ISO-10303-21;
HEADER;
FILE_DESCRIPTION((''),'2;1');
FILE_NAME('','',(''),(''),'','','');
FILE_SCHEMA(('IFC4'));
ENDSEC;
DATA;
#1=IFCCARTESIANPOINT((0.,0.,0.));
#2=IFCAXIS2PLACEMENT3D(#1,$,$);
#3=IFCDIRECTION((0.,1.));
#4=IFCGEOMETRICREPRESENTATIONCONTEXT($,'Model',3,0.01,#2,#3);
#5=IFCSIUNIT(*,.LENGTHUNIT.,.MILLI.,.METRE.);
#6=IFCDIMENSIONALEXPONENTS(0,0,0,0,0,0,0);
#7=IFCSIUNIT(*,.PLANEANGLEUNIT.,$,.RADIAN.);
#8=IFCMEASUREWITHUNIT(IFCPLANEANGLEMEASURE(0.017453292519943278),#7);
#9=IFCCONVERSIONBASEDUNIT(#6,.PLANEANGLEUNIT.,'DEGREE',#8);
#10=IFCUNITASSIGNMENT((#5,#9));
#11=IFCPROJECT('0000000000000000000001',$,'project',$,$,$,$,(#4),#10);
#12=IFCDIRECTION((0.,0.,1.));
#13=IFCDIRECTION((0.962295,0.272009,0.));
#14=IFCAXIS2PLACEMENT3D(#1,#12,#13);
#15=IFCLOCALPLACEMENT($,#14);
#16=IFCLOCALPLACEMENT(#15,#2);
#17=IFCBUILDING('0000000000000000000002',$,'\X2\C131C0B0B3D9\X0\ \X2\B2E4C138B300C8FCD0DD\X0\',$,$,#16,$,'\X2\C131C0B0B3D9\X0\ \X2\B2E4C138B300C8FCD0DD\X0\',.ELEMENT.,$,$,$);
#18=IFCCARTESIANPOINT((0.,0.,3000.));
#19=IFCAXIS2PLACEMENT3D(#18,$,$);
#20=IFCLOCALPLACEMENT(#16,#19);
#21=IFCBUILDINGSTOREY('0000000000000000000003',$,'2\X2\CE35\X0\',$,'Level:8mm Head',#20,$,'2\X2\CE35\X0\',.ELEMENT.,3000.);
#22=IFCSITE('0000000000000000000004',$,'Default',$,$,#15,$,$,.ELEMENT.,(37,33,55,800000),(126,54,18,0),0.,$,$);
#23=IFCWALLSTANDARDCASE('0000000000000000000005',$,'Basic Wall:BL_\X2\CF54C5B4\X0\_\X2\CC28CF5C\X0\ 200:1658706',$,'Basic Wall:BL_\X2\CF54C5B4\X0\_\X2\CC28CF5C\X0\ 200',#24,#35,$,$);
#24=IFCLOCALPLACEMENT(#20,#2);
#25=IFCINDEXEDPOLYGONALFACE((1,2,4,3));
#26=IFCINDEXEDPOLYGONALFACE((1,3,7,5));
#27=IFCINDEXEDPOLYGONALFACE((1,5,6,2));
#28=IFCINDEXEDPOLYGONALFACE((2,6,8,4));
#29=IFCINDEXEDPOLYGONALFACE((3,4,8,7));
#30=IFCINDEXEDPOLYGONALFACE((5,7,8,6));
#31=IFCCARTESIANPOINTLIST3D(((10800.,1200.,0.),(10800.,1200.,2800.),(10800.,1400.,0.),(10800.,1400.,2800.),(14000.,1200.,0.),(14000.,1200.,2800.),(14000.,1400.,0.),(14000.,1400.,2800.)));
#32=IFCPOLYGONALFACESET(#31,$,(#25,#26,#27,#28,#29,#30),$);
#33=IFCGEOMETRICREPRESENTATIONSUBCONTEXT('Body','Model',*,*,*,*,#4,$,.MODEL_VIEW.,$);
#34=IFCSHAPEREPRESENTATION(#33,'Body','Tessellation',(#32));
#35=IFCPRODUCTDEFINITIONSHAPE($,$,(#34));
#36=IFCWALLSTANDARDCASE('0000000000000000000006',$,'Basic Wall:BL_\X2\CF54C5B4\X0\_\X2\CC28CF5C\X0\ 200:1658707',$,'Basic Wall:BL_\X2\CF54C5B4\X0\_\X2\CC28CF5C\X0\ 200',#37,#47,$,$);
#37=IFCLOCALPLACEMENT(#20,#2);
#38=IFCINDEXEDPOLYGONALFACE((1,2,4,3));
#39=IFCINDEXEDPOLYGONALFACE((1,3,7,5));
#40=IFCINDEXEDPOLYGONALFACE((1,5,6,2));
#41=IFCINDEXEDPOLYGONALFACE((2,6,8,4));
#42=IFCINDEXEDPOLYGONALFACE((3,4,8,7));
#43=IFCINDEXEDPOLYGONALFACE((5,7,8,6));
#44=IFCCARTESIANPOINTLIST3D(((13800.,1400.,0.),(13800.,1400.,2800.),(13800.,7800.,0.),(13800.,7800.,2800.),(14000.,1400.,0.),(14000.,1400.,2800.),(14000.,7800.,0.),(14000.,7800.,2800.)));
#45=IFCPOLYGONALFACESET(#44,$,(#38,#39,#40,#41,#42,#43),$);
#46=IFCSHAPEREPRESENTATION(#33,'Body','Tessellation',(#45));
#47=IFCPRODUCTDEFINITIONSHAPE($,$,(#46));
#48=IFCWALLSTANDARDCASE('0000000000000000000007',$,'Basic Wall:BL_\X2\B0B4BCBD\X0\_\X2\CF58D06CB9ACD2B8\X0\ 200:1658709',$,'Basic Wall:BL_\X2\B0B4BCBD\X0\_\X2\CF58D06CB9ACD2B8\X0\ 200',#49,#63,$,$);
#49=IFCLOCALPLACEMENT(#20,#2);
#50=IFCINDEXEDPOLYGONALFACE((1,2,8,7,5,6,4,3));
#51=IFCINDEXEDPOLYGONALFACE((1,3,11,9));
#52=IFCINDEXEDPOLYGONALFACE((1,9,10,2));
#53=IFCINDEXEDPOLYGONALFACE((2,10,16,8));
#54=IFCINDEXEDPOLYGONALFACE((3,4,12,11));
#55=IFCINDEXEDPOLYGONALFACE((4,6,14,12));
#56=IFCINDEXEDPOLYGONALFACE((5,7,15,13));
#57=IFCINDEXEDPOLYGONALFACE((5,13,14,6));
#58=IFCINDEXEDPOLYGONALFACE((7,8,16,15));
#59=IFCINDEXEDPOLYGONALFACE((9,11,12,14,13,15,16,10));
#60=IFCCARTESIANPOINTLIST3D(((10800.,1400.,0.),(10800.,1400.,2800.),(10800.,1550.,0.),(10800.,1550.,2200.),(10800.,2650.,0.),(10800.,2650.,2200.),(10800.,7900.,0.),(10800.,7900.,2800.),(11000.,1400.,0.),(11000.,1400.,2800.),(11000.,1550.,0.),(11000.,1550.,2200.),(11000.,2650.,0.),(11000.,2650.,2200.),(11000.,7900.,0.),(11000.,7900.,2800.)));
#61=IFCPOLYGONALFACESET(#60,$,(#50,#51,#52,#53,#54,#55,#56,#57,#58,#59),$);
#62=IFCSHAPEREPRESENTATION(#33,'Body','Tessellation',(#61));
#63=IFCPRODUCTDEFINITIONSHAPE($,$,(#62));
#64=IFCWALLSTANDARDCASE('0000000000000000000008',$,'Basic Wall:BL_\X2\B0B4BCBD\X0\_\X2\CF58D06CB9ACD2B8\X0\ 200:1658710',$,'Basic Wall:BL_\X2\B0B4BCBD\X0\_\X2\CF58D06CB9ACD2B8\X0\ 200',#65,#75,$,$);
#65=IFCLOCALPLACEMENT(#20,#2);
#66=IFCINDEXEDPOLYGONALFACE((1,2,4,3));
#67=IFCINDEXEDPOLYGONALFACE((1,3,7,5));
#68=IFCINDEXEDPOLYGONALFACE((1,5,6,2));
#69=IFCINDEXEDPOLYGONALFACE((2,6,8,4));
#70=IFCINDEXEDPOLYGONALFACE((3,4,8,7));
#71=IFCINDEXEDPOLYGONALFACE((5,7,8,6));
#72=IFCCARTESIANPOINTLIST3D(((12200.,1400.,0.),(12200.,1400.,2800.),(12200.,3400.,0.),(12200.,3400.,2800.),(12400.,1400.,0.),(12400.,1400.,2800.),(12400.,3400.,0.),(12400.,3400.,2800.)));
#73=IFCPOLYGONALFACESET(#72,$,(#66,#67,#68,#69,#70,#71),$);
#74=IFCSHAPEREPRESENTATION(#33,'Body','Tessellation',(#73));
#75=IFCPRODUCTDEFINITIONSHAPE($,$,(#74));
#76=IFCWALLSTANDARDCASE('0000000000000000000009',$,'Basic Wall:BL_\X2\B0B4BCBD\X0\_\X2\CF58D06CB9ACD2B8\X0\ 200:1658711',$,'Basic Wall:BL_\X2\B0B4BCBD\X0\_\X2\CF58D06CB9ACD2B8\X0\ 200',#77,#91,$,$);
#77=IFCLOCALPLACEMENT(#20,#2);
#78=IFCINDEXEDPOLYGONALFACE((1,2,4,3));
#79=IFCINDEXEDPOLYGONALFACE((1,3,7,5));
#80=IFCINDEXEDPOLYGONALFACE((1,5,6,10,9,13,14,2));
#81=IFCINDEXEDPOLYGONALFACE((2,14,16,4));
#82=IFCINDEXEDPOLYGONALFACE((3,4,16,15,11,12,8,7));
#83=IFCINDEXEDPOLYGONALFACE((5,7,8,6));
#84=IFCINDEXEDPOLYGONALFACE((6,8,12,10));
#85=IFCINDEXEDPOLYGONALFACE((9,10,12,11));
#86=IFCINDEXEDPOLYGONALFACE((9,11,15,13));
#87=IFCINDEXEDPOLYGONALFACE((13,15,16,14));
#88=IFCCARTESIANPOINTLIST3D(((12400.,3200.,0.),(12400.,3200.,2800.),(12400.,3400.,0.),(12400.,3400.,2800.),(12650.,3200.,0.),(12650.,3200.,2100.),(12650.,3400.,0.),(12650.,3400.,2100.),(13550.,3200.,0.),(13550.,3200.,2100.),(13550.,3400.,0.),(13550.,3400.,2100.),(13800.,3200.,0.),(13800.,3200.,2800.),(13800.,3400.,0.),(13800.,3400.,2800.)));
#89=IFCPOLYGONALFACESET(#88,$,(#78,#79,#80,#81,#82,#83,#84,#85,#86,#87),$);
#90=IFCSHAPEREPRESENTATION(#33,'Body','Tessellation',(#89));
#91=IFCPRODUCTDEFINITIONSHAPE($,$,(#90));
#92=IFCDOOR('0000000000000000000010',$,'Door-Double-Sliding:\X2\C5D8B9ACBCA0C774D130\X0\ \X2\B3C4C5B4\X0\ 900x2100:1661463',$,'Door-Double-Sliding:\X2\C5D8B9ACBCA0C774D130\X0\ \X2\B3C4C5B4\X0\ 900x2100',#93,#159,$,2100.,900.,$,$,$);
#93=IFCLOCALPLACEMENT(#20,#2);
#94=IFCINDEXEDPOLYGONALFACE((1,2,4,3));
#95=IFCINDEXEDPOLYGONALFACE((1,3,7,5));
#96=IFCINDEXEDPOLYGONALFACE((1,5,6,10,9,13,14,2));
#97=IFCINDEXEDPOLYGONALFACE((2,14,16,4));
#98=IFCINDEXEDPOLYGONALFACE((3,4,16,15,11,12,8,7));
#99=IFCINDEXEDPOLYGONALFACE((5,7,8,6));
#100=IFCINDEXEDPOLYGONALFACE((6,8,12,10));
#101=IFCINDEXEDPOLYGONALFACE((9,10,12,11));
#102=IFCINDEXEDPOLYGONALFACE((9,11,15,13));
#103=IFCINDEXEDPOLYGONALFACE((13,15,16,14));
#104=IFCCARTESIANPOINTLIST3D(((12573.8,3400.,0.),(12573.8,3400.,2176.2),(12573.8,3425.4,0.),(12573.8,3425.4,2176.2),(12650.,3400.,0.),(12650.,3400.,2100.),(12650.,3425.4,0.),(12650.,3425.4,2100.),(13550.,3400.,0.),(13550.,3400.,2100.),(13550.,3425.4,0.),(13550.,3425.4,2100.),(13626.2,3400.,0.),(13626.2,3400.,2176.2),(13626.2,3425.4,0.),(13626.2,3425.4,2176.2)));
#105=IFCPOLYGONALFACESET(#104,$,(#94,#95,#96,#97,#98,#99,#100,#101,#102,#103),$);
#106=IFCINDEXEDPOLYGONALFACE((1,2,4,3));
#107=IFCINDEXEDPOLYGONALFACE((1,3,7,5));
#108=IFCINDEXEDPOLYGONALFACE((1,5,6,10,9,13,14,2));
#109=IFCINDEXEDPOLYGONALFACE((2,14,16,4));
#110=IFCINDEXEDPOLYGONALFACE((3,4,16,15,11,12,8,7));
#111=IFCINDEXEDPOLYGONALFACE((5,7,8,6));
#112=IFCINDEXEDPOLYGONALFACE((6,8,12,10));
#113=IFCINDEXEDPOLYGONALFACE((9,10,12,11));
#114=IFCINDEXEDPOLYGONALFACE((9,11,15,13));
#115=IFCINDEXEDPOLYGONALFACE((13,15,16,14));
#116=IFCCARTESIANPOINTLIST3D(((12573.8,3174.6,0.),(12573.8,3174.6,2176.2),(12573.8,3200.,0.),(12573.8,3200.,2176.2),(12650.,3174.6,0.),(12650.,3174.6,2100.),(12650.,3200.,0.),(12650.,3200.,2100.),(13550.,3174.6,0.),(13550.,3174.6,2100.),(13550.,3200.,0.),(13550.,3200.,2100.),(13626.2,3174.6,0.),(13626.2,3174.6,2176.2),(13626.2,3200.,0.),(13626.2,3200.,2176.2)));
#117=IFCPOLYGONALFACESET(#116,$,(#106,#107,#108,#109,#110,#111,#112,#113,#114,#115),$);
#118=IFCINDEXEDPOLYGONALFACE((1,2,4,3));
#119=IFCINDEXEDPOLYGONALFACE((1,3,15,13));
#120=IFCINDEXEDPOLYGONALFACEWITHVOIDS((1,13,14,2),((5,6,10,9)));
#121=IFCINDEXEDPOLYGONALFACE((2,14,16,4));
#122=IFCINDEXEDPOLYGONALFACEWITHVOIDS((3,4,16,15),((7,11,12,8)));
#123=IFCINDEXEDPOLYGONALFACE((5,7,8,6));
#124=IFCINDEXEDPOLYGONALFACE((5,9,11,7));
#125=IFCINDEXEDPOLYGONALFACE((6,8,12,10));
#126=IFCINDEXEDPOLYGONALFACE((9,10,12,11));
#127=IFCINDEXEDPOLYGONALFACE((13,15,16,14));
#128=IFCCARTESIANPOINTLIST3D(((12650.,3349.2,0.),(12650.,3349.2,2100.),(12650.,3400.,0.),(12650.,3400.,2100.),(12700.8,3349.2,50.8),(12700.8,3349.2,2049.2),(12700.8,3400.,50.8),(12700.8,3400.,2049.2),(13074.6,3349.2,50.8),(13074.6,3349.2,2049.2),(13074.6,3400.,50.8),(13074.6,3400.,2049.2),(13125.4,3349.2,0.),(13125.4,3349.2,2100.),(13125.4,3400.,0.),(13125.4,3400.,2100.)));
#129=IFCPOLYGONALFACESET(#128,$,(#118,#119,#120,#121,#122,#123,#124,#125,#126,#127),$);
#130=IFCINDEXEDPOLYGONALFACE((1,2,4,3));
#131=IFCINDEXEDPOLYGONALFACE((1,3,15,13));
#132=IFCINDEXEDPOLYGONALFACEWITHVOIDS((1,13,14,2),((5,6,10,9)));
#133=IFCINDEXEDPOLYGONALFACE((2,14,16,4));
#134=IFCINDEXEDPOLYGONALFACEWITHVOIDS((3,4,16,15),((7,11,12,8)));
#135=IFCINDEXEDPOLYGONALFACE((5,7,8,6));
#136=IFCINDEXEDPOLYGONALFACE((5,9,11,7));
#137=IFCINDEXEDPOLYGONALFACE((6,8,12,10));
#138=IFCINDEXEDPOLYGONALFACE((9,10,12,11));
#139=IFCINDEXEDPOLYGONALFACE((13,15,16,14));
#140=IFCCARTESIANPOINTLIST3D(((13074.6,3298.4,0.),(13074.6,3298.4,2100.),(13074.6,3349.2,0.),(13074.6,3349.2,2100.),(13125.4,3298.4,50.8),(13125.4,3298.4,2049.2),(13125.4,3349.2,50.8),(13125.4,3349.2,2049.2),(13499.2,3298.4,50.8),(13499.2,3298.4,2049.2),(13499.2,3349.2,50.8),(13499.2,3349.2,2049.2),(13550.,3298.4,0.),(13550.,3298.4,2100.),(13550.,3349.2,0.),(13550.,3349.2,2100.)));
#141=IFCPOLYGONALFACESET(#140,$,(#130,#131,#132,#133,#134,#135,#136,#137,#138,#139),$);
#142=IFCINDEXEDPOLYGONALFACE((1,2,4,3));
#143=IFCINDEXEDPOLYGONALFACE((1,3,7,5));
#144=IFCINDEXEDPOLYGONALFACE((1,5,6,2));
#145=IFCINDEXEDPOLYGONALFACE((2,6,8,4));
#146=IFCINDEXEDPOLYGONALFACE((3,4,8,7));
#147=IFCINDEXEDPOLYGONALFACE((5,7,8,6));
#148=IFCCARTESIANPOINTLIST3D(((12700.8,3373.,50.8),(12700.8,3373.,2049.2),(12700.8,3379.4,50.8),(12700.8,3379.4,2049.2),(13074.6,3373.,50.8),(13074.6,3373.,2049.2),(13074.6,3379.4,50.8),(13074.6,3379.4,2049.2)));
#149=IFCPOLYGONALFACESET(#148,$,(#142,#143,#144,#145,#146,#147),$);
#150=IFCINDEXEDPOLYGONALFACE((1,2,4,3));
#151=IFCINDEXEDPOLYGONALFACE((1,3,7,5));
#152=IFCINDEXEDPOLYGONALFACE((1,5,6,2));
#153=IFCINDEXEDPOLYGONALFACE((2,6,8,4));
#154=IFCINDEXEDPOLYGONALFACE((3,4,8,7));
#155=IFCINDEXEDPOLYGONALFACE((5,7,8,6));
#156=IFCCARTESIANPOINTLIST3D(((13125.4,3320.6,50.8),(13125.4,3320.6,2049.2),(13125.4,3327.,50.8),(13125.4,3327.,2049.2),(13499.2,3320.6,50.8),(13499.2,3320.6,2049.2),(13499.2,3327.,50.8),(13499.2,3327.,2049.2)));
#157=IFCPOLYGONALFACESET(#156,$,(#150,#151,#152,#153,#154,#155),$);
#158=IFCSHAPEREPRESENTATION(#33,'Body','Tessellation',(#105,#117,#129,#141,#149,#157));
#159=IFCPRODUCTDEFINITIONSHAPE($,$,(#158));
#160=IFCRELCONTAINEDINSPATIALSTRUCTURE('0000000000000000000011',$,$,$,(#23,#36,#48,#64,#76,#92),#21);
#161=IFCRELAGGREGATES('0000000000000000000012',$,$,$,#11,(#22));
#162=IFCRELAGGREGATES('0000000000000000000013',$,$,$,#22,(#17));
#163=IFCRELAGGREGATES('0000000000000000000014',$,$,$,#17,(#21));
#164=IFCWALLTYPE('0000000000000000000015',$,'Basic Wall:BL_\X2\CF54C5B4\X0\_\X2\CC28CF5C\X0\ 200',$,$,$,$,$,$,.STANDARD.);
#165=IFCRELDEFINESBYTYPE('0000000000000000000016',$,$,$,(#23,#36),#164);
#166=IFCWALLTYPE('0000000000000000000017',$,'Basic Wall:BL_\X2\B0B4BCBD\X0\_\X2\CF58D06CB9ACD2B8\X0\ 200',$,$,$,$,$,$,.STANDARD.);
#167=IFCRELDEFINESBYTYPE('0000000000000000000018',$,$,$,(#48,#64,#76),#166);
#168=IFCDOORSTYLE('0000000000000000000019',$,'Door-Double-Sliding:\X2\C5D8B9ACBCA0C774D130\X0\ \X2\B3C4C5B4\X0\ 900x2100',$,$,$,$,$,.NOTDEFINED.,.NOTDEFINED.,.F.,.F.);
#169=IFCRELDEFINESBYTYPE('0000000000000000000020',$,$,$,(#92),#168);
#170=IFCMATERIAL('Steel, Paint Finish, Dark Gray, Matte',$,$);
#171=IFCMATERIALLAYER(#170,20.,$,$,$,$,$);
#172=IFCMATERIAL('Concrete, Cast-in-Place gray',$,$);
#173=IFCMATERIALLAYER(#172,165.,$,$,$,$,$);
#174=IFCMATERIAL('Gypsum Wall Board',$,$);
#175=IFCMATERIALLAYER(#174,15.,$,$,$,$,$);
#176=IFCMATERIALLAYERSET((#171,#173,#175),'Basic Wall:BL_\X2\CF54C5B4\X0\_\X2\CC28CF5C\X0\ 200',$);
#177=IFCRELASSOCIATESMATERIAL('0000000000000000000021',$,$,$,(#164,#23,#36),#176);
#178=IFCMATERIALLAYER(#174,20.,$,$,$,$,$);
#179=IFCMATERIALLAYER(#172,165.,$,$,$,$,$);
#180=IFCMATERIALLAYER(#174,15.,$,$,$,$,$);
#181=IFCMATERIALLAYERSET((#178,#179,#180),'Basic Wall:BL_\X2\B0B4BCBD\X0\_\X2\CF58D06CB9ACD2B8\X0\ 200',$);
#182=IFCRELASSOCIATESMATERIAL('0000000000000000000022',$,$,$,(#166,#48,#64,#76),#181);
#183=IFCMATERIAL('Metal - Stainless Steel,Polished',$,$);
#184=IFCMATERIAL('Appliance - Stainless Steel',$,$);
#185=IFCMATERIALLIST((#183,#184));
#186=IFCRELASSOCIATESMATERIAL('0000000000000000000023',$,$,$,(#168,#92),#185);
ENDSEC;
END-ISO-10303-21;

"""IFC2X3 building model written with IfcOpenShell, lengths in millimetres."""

from ifc_helpers import new_model, entity, si_unit, converted_unit, direction, frame, frame_2d, origin, place, context, subcontext, project, spatial, polyline, rectangle, outline, extrude, source, transform, mapped, material, material_list, layer, layer_set, layer_usage, type_object, type_shapes, element, fill, save


model = new_model("IFC2X3")

# Units and contexts
model_context = context("Model", 3, precision=0.01, world=origin(), true_north=direction((0.0, 1.0)))
body_context = subcontext(model_context, "Body", "Model", "MODEL_VIEW")
ifc_project = project(units=[si_unit("LENGTHUNIT", "METRE", prefix="MILLI"), converted_unit("PLANEANGLEUNIT", "DEGREE", entity("IfcPlaneAngleMeasure", 0.017453292519943278), si_unit("PLANEANGLEUNIT", "RADIAN"), dimensions=[0, 0, 0, 0, 0, 0, 0])], contexts=[model_context])

# Site, building, storey
site_placement = place(None, frame((0.0, 0.0, 0.0), z_axis=(0.0, 0.0, 1.0), x_axis=(0.962295, 0.272009, 0.0)))
site = spatial("IfcSite", under=ifc_project, at=site_placement, Name="Default", CompositionType="ELEMENT", RefLatitude=(37, 33, 55, 800000), RefLongitude=(126, 54, 18, 0), RefElevation=0.0)
building_placement = place(site_placement, origin())
building = spatial("IfcBuilding", under=site, at=building_placement, Name="성산동 다세대주택", LongName="성산동 다세대주택", CompositionType="ELEMENT")
storey_placement = place(building_placement, frame((0.0, 0.0, 3000.0)))
storey = spatial("IfcBuildingStorey", under=building, at=storey_placement, Name="2층", ObjectType="Level:8mm Head", LongName="2층", CompositionType="ELEMENT", Elevation=3000.0)

# Walls
ifc_material_1 = material(Name="Steel, Paint Finish, Dark Gray, Matte")
ifc_layer_1 = layer(ifc_material_1, 20.0)
ifc_material_2 = material(Name="Concrete, Cast-in-Place gray")
ifc_layer_2 = layer(ifc_material_2, 165.0)
ifc_material_3 = material(Name="Gypsum Wall Board")
ifc_layer_3 = layer(ifc_material_3, 15.0)
ifc_layer_set_1 = layer_set([ifc_layer_1, ifc_layer_2, ifc_layer_3], Name="Basic Wall:BL_코어_차콜 200")
ifc_layer_usage_1 = layer_usage(ifc_layer_set_1, "AXIS2", "POSITIVE", -100.0)
wall_type_1 = type_object("IfcWallType", Name="Basic Wall:BL_코어_차콜 200", PredefinedType="STANDARD", material=ifc_layer_set_1)
wall_1_placement = place(storey_placement, frame((10800.0, 1300.0, 0.0)))
element("IfcWallStandardCase", 1, at=wall_1_placement, inside=storey, type_object=wall_type_1, material=ifc_layer_usage_1, Name="Basic Wall:BL_코어_차콜 200:1658706", ObjectType="Basic Wall:BL_코어_차콜 200", context=body_context, shape_type="SweptSolid", body=[
    extrude(rectangle(XDim=3200.0, YDim=200.0, at=frame_2d((1600.0, 0.0), x_axis=(-1.0, 0.0))), origin(), (0.0, 0.0, 1.0), 2800.0),
])
ifc_layer_usage_2 = layer_usage(ifc_layer_set_1, "AXIS2", "POSITIVE", -100.0)
wall_2_placement = place(storey_placement, frame((13900.0, 1400.0, 0.0), z_axis=(0.0, 0.0, 1.0), x_axis=(0.0, 1.0, 0.0)))
element("IfcWallStandardCase", 2, at=wall_2_placement, inside=storey, type_object=wall_type_1, material=ifc_layer_usage_2, Name="Basic Wall:BL_코어_차콜 200:1658707", ObjectType="Basic Wall:BL_코어_차콜 200", context=body_context, shape_type="SweptSolid", body=[
    extrude(rectangle(XDim=6400.0, YDim=200.0, at=frame_2d((3200.0, 0.0), x_axis=(-1.0, 0.0))), origin(), (0.0, 0.0, 1.0), 2800.0),
])

# Wall, openings
ifc_layer_4 = layer(ifc_material_3, 20.0)
ifc_layer_5 = layer(ifc_material_2, 165.0)
ifc_layer_6 = layer(ifc_material_3, 15.0)
ifc_layer_set_2 = layer_set([ifc_layer_4, ifc_layer_5, ifc_layer_6], Name="Basic Wall:BL_내벽_콘크리트 200")
ifc_layer_usage_3 = layer_usage(ifc_layer_set_2, "AXIS2", "NEGATIVE", 100.0)
wall_type_2 = type_object("IfcWallType", Name="Basic Wall:BL_내벽_콘크리트 200", PredefinedType="STANDARD", material=ifc_layer_set_2)
wall_3_placement = place(storey_placement, frame((10900.0, 7900.0, 0.0), z_axis=(0.0, 0.0, 1.0), x_axis=(0.0, -1.0, 0.0)))
wall_3 = element("IfcWallStandardCase", 3, at=wall_3_placement, inside=storey, type_object=wall_type_2, material=ifc_layer_usage_3, Name="Basic Wall:BL_내벽_콘크리트 200:1658709", ObjectType="Basic Wall:BL_내벽_콘크리트 200", context=body_context, shape_type="SweptSolid", body=[
    extrude(rectangle(XDim=6500.0, YDim=200.0, at=frame_2d((3250.0, 0.0), x_axis=(1.0, 0.0))), origin(), (0.0, 0.0, 1.0), 2800.0),
])
opening_1_placement = place(wall_3_placement, origin())
element("IfcOpeningElement", 4, at=opening_1_placement, cuts=wall_3, ObjectType="Opening", context=body_context, shape_type="SweptSolid", body=[
    extrude(rectangle(XDim=2200.0, YDim=1100.0, at=frame_2d((0.0, 0.0), x_axis=(0.0, 1.0))), frame((5800.0, -1624.0, 3900.0), z_axis=(0.0, 1.0, 0.0), x_axis=(-1.0, 0.0, 0.0)), (0.0, 0.0, 1.0), 3048.0),
])
opening_2_placement = place(wall_3_placement, frame((5250.0, -100.0, 0.0)))
element("IfcOpeningElement", 5, at=opening_2_placement, cuts=wall_3, ObjectType="Opening", context=body_context, shape_type="SweptSolid", body=[
    extrude(rectangle(XDim=2200.0, YDim=1100.0, at=frame_2d((1100.0, 550.0), x_axis=(1.0, 0.0))), frame((0.0, 0.0, 0.0), z_axis=(0.0, 1.0, 0.0), x_axis=(0.0, 0.0, 1.0)), (0.0, 0.0, 1.0), 200.0),
])

# Wall
ifc_layer_usage_4 = layer_usage(ifc_layer_set_2, "AXIS2", "NEGATIVE", 100.0)
wall_4_placement = place(storey_placement, frame((12300.0, 1400.0, 0.0), z_axis=(0.0, 0.0, 1.0), x_axis=(0.0, 1.0, 0.0)))
element("IfcWallStandardCase", 6, at=wall_4_placement, inside=storey, type_object=wall_type_2, material=ifc_layer_usage_4, Name="Basic Wall:BL_내벽_콘크리트 200:1658710", ObjectType="Basic Wall:BL_내벽_콘크리트 200", context=body_context, shape_type="SweptSolid", body=[
    extrude(rectangle(XDim=2000.0, YDim=200.0, at=frame_2d((1000.0, 0.0), x_axis=(-1.0, 0.0))), origin(), (0.0, 0.0, 1.0), 2800.0),
])

# Wall, opening, door
ifc_layer_usage_5 = layer_usage(ifc_layer_set_2, "AXIS2", "NEGATIVE", 100.0)
wall_5_placement = place(storey_placement, frame((12400.0, 3300.0, 0.0)))
wall_5 = element("IfcWallStandardCase", 7, at=wall_5_placement, inside=storey, type_object=wall_type_2, material=ifc_layer_usage_5, Name="Basic Wall:BL_내벽_콘크리트 200:1658711", ObjectType="Basic Wall:BL_내벽_콘크리트 200", context=body_context, shape_type="SweptSolid", body=[
    extrude(rectangle(XDim=1400.0, YDim=200.0, at=frame_2d((700.0, 0.0), x_axis=(1.0, 0.0))), origin(), (0.0, 0.0, 1.0), 2800.0),
])
opening_3_placement = place(wall_5_placement, frame((250.0, -100.0, 0.0)))
opening_3 = element("IfcOpeningElement", 8, at=opening_3_placement, cuts=wall_5, ObjectType="Opening", context=body_context, shape_type="SweptSolid", body=[
    extrude(rectangle(XDim=2100.0, YDim=900.0, at=frame_2d((1050.0, 450.0), x_axis=(-1.0, 0.0))), frame((0.0, 0.0, 0.0), z_axis=(0.0, 1.0, 0.0), x_axis=(0.0, 0.0, 1.0)), (0.0, 0.0, 1.0), 200.0),
])
ifc_material_4 = material(Name="Metal - Stainless Steel,Polished")
ifc_material_5 = material(Name="Appliance - Stainless Steel")
ifc_material_list = material_list([ifc_material_4, ifc_material_5])
door_style = type_object("IfcDoorStyle", Name="Door-Double-Sliding:엘리베이터 도어 900x2100", ConstructionType="NOTDEFINED", OperationType="NOTDEFINED", ParameterTakesPrecedence=False, Sizeable=False, material=ifc_material_list)
shared_shape_1 = source(origin(), body_context, "Body", "SweptSolid", [
    extrude(outline(polyline([(-526.2, -1069.1), (-450.0, -1069.1), (-450.0, 1030.9), (450.0, 1031.0), (450.0, -1069.0), (526.2, -1069.0), (526.2, 1107.1), (-526.2, 1107.1), (-526.2, -1069.1)])), frame((450.0, 200.0, 1069.0), z_axis=(0.0, 1.0, 0.0), x_axis=(-1.0, 0.0, 0.0)), (0.0, 0.0, 1.0), 25.4),
    extrude(outline(polyline([(-1069.0, -526.2), (1107.1, -526.2), (1107.1, 526.2), (-1069.0, 526.2), (-1069.0, 450.0), (1030.9, 450.0), (1030.9, -450.0), (-1069.0, -450.0), (-1069.0, -526.2)])), frame((450.0, -25.4, 1069.0), z_axis=(0.0, 1.0, 0.0), x_axis=(0.0, 0.0, 1.0)), (0.0, 0.0, 1.0), 25.4),
    extrude(outline(polyline([(-1050.0, -237.7), (1050.0, -237.7), (1050.0, 237.7), (-1050.0, 237.7), (-1050.0, -237.7)]), holes=[polyline([(-999.2, -186.9), (-999.2, 186.9), (999.2, 186.9), (999.2, -186.9), (-999.2, -186.9)])]), frame((237.7, 149.2, 1050.0), z_axis=(0.0, 1.0, 0.0), x_axis=(0.0, 0.0, -1.0)), (0.0, 0.0, 1.0), 50.8),
    extrude(outline(polyline([(-237.7, -1050.0), (237.7, -1050.0), (237.7, 1050.0), (-237.7, 1050.0), (-237.7, -1050.0)]), holes=[polyline([(-186.9, -999.2), (-186.9, 999.2), (186.9, 999.2), (186.9, -999.2), (-186.9, -999.2)])]), frame((662.3, 98.4, 1050.0), z_axis=(0.0, 1.0, 0.0), x_axis=(1.0, 0.0, 0.0)), (0.0, 0.0, 1.0), 50.8),
    extrude(rectangle(XDim=6.4, YDim=373.8, at=frame_2d((0.0, 0.0), x_axis=(1.0, 0.0))), frame((237.7, 176.2, 50.8), z_axis=(0.0, 0.0, 1.0), x_axis=(0.0, 1.0, 0.0)), (0.0, 0.0, 1.0), 1998.4),
    extrude(rectangle(XDim=6.3, YDim=373.8, at=frame_2d((0.0, 0.0), x_axis=(1.0, 0.0))), frame((662.3, 123.8, 50.8), z_axis=(0.0, 0.0, 1.0), x_axis=(0.0, -1.0, 0.0)), (0.0, 0.0, 1.0), 1998.4),
])
type_shapes(door_style, [shared_shape_1])
door_placement = place(opening_3_placement, origin())
door = element("IfcDoor", 9, at=door_placement, inside=storey, type_object=door_style, material=ifc_material_list, Name="Door-Double-Sliding:엘리베이터 도어 900x2100:1661463", ObjectType="Door-Double-Sliding:엘리베이터 도어 900x2100", OverallHeight=2100.0, OverallWidth=900.0, context=body_context, shape_type="MappedRepresentation", body=[
    mapped(shared_shape_1, transform((0.0, 0.0, 0.0), scale=1.0)),
])
fill(opening_3, door)

save(model, "model.ifc")
